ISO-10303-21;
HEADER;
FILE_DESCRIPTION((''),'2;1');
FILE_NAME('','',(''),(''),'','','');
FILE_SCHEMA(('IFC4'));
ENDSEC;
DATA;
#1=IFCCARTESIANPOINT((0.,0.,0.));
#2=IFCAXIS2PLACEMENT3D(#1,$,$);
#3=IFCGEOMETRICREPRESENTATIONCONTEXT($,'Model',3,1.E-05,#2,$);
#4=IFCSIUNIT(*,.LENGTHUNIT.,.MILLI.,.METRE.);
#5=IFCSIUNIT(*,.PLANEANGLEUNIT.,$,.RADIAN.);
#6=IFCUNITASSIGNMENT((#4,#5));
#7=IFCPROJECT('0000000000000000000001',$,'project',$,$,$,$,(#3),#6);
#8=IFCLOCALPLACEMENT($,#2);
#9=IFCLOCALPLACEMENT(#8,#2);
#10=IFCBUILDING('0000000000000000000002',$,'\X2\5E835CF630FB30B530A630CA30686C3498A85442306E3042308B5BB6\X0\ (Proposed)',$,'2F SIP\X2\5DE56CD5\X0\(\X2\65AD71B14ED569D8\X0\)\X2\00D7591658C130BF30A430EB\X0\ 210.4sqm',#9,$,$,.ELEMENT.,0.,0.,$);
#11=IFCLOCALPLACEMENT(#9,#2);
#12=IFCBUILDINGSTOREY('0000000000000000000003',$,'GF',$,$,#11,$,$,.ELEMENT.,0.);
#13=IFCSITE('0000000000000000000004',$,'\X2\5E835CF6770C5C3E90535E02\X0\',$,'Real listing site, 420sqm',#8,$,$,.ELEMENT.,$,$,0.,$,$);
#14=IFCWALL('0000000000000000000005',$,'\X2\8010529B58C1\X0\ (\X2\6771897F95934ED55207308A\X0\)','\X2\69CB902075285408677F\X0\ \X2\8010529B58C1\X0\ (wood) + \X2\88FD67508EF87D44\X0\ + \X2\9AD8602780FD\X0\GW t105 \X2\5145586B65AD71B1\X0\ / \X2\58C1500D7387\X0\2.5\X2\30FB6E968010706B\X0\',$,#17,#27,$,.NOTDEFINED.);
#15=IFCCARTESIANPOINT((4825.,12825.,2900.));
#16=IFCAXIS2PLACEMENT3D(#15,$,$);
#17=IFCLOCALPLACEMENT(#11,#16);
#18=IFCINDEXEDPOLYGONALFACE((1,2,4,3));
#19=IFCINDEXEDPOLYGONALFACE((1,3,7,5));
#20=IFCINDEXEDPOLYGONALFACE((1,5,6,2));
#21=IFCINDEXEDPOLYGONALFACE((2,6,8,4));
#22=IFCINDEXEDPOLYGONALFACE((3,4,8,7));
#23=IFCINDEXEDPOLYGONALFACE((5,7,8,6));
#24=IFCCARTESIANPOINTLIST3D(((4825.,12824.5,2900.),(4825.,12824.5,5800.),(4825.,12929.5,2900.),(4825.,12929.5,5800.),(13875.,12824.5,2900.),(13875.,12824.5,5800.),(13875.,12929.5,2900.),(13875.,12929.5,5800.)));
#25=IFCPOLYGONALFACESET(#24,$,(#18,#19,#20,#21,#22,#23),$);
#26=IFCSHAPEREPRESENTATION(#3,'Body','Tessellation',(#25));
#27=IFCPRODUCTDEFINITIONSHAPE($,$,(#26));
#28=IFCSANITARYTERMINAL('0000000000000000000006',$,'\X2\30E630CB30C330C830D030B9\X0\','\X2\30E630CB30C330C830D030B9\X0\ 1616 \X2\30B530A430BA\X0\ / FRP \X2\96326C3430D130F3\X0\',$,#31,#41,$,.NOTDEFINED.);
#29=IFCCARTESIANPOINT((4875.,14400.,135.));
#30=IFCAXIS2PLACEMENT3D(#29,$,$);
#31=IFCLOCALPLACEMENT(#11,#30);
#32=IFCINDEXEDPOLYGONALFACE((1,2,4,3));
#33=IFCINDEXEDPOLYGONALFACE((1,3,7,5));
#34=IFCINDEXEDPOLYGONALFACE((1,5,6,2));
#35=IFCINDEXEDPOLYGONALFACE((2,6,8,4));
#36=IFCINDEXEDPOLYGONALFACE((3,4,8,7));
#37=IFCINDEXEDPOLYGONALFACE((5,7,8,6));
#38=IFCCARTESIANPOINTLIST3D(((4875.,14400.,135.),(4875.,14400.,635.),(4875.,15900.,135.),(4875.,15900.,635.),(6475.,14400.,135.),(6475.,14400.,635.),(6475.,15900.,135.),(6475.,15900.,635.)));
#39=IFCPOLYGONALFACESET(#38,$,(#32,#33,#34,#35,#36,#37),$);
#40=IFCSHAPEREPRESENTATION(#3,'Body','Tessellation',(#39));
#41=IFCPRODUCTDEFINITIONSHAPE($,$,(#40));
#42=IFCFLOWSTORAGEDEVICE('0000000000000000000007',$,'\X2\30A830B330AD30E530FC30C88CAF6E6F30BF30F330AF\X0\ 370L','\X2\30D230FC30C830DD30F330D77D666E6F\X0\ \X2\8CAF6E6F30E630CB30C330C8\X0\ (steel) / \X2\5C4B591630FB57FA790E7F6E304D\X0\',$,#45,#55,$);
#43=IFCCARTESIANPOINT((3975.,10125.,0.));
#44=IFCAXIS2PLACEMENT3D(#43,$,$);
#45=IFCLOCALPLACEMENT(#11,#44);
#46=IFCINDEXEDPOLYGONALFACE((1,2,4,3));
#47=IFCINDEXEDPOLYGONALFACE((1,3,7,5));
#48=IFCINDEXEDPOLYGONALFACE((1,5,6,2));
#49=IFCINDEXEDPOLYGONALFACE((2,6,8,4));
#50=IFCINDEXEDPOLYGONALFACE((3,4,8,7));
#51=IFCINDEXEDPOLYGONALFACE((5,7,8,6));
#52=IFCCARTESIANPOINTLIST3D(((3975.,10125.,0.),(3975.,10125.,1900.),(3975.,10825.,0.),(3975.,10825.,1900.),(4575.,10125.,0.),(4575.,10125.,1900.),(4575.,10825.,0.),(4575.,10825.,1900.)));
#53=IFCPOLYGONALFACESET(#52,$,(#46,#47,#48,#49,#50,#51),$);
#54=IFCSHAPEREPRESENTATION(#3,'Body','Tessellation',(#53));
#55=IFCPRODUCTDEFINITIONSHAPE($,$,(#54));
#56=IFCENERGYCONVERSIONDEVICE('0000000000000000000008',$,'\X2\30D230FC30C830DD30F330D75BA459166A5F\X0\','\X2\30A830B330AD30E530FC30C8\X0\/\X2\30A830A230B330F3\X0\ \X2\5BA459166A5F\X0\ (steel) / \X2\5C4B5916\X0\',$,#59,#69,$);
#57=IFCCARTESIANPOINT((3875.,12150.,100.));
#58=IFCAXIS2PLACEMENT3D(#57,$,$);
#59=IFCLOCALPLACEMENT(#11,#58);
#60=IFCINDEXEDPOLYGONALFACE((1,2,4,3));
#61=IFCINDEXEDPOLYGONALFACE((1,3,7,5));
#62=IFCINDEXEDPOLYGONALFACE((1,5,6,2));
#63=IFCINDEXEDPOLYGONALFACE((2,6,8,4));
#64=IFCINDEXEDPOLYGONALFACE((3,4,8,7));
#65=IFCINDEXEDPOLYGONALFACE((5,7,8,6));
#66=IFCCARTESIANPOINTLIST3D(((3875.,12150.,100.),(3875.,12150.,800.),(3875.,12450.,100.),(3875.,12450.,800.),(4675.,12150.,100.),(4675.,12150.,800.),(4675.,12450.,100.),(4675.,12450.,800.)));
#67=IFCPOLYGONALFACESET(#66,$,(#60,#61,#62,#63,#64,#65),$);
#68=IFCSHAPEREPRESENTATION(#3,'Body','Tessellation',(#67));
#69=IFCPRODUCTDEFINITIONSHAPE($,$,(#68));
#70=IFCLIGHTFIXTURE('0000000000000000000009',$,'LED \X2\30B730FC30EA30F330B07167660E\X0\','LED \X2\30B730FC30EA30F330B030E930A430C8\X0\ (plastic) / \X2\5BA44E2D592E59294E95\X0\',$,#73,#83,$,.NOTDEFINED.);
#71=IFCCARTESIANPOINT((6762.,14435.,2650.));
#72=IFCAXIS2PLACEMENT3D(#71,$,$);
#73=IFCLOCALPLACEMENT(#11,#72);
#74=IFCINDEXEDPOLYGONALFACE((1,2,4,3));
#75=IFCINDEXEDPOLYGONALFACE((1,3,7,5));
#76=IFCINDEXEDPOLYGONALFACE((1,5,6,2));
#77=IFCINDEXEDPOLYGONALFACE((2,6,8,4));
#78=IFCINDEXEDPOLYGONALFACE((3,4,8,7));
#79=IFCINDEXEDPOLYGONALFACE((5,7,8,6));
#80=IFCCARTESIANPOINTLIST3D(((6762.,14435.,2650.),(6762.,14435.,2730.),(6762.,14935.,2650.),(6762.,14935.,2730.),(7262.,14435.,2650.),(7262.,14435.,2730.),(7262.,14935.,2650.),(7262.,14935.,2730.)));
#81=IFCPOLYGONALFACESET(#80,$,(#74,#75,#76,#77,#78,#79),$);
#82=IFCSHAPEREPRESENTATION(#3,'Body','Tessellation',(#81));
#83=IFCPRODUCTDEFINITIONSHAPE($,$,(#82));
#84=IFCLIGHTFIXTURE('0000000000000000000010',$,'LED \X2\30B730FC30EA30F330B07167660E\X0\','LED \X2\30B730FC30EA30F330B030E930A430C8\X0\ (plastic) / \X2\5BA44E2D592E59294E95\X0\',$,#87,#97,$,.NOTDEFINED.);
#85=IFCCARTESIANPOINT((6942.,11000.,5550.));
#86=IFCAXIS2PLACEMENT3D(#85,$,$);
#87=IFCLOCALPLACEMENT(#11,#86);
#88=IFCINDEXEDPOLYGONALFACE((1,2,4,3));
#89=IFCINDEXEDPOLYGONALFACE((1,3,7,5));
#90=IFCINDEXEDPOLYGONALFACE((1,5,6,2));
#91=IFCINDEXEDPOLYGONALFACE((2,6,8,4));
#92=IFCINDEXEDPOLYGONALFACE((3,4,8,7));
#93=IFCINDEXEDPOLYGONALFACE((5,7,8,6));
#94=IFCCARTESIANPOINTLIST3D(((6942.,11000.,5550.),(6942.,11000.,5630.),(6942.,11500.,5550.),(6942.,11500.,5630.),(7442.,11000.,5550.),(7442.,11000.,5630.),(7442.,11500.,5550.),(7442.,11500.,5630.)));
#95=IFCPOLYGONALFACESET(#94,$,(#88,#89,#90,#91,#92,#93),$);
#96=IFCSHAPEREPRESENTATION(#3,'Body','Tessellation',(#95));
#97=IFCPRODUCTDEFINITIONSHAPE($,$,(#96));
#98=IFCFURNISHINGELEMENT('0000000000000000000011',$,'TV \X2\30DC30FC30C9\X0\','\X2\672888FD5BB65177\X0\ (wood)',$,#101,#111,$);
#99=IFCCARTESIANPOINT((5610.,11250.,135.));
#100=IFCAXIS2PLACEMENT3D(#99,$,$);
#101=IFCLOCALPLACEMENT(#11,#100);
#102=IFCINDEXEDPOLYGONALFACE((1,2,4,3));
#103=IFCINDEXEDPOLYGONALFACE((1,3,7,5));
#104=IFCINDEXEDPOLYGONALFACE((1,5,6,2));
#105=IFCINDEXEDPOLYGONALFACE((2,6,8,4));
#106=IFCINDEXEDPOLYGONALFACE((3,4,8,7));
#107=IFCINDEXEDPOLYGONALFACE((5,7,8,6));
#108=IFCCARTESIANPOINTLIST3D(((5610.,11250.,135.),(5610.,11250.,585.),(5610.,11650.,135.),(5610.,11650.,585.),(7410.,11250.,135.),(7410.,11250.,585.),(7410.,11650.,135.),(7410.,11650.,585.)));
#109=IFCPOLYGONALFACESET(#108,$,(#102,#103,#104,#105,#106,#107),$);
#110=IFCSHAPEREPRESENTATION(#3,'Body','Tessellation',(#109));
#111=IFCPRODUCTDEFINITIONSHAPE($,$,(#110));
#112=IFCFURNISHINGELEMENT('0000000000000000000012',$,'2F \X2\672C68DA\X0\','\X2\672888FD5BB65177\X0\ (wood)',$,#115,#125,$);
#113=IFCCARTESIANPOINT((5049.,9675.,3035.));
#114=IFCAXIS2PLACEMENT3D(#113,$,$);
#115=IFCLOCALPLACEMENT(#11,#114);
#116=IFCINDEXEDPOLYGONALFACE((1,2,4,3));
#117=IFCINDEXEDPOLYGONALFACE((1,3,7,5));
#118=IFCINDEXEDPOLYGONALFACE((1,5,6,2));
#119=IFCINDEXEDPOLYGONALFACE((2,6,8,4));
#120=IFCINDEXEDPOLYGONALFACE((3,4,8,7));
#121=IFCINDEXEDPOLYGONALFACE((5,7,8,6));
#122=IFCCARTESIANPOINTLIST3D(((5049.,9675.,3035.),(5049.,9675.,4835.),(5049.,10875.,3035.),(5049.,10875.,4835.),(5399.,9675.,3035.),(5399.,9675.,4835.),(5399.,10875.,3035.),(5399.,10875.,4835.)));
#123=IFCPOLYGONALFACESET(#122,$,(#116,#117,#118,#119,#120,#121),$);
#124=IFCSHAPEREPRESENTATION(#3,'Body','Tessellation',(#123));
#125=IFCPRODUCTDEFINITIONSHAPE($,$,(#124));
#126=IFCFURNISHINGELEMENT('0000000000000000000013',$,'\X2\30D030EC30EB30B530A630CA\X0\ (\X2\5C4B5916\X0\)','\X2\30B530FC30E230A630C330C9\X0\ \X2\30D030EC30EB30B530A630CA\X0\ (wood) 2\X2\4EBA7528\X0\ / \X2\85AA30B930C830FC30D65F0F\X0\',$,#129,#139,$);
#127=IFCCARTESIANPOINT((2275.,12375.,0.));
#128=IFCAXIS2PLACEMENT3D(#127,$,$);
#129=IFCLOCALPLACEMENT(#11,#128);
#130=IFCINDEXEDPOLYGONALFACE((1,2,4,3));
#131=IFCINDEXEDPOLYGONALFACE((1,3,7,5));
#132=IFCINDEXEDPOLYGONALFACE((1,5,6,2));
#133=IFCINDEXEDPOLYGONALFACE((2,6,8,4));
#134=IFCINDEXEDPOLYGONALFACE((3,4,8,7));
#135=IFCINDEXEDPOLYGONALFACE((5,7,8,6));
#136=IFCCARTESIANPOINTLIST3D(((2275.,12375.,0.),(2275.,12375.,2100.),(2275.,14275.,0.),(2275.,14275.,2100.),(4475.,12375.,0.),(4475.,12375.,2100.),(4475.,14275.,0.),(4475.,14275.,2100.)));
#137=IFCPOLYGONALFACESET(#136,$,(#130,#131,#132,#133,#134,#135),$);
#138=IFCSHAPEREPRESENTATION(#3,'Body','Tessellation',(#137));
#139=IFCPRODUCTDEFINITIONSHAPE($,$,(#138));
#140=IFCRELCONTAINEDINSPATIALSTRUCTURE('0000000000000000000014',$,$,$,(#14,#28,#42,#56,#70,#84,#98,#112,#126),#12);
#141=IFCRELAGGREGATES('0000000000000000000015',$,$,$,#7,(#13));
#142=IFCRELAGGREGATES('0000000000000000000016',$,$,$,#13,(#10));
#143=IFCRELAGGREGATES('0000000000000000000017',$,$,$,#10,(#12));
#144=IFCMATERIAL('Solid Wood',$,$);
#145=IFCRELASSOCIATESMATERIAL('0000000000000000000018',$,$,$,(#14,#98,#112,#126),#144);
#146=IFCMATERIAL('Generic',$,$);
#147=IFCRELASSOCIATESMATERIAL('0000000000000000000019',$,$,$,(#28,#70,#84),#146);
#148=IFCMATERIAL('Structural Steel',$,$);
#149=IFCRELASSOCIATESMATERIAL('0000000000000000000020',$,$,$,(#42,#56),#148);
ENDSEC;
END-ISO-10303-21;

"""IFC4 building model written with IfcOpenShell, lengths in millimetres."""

from ifc_helpers import new_model, si_unit, frame, frame_2d, origin, place, context, project, spatial, rectangle, extrude, material, element, save


model = new_model("IFC4")

# Units and contexts
model_context = context("Model", 3, precision=1e-05, world=origin())
ifc_project = project(units=[si_unit("LENGTHUNIT", "METRE", prefix="MILLI"), si_unit("PLANEANGLEUNIT", "RADIAN")], contexts=[model_context])

# Site, building, storey
site_placement = place(None, origin())
site = spatial("IfcSite", under=ifc_project, at=site_placement, Name="広島県尾道市", ObjectType="Real listing site, 420sqm", CompositionType="ELEMENT", RefElevation=0.0)
building_placement = place(site_placement, origin())
building = spatial("IfcBuilding", under=site, at=building_placement, Name="広島・サウナと水風呂のある家 (Proposed)", ObjectType="2F SIP工法(断熱仕様)×外壁タイル 210.4sqm", CompositionType="ELEMENT", ElevationOfRefHeight=0.0, ElevationOfTerrain=0.0)
storey_placement = place(building_placement, origin())
storey = spatial("IfcBuildingStorey", under=building, at=storey_placement, Name="GF", CompositionType="ELEMENT", Elevation=0.0)

# Shared definitions
ifc_material_1 = material(Name="Solid Wood")

# Wall
wall_1_placement = place(storey_placement, frame((4825.0, 12825.0, 2900.0)))
element("IfcWall", 1, at=wall_1_placement, inside=storey, material=ifc_material_1, Name="耐力壁 (東西間仕切り)", Description="構造用合板 耐力壁 (wood) + 製材軸組 + 高性能GW t105 充填断熱 / 壁倍率2.5・準耐火", PredefinedType="NOTDEFINED", context=model_context, shape_type="SweptSolid", body=[
    extrude(rectangle(XDim=9050.0, YDim=105.0, at=frame_2d((4525.0, 52.0))), frame((4825.0, 12825.0, 2900.0)), (0.0, 0.0, 1.0), 2900.0),
])

# Sanitary terminal
ifc_material_2 = material(Name="Generic")
sanitary_terminal_placement = place(storey_placement, frame((4875.0, 14400.0, 135.0)))
element("IfcSanitaryTerminal", 2, at=sanitary_terminal_placement, inside=storey, material=ifc_material_2, Name="ユニットバス", Description="ユニットバス 1616 サイズ / FRP 防水パン", PredefinedType="NOTDEFINED", context=model_context, shape_type="SweptSolid", body=[
    extrude(rectangle(XDim=1600.0, YDim=1500.0, at=frame_2d((800.0, 750.0))), frame((4875.0, 14400.0, 135.0)), (0.0, 0.0, 1.0), 500.0),
])

# Flow storage device
ifc_material_3 = material(Name="Structural Steel")
flow_storage_device_placement = place(storey_placement, frame((3975.0, 10125.0, 0.0)))
element("IfcFlowStorageDevice", 3, at=flow_storage_device_placement, inside=storey, material=ifc_material_3, Name="エコキュート貯湯タンク 370L", Description="ヒートポンプ給湯 貯湯ユニット (steel) / 屋外・基礎置き", context=model_context, shape_type="SweptSolid", body=[
    extrude(rectangle(XDim=600.0, YDim=700.0, at=frame_2d((300.0, 350.0))), frame((3975.0, 10125.0, 0.0)), (0.0, 0.0, 1.0), 1900.0),
])

# Energy conversion device
energy_conversion_device_placement = place(storey_placement, frame((3875.0, 12150.0, 100.0)))
element("IfcEnergyConversionDevice", 4, at=energy_conversion_device_placement, inside=storey, material=ifc_material_3, Name="ヒートポンプ室外機", Description="エコキュート/エアコン 室外機 (steel) / 屋外", context=model_context, shape_type="SweptSolid", body=[
    extrude(rectangle(XDim=800.0, YDim=300.0, at=frame_2d((400.0, 150.0))), frame((3875.0, 12150.0, 100.0)), (0.0, 0.0, 1.0), 700.0),
])

# Light fixtures
light_fixture_1_placement = place(storey_placement, frame((6762.0, 14435.0, 2650.0)))
element("IfcLightFixture", 5, at=light_fixture_1_placement, inside=storey, material=ifc_material_2, Name="LED シーリング照明", Description="LED シーリングライト (plastic) / 室中央天井", PredefinedType="NOTDEFINED", context=model_context, shape_type="SweptSolid", body=[
    extrude(rectangle(XDim=500.0, YDim=500.0, at=frame_2d((250.0, 250.0))), frame((6762.0, 14435.0, 2650.0)), (0.0, 0.0, 1.0), 80.0),
])
light_fixture_2_placement = place(storey_placement, frame((6942.0, 11000.0, 5550.0)))
element("IfcLightFixture", 6, at=light_fixture_2_placement, inside=storey, material=ifc_material_2, Name="LED シーリング照明", Description="LED シーリングライト (plastic) / 室中央天井", PredefinedType="NOTDEFINED", context=model_context, shape_type="SweptSolid", body=[
    extrude(rectangle(XDim=500.0, YDim=500.0, at=frame_2d((250.0, 250.0))), frame((6942.0, 11000.0, 5550.0)), (0.0, 0.0, 1.0), 80.0),
])

# Furnishing elements
furnishing_1_placement = place(storey_placement, frame((5610.0, 11250.0, 135.0)))
element("IfcFurnishingElement", 7, at=furnishing_1_placement, inside=storey, material=ifc_material_1, Name="TV ボード", Description="木製家具 (wood)", context=model_context, shape_type="SweptSolid", body=[
    extrude(rectangle(XDim=1800.0, YDim=400.0, at=frame_2d((900.0, 200.0))), frame((5610.0, 11250.0, 135.0)), (0.0, 0.0, 1.0), 450.0),
])
furnishing_2_placement = place(storey_placement, frame((5049.0, 9675.0, 3035.0)))
element("IfcFurnishingElement", 8, at=furnishing_2_placement, inside=storey, material=ifc_material_1, Name="2F 本棚", Description="木製家具 (wood)", context=model_context, shape_type="SweptSolid", body=[
    extrude(rectangle(XDim=350.0, YDim=1200.0, at=frame_2d((175.0, 600.0))), frame((5049.0, 9675.0, 3035.0)), (0.0, 0.0, 1.0), 1800.0),
])
furnishing_3_placement = place(storey_placement, frame((2275.0, 12375.0, 0.0)))
element("IfcFurnishingElement", 9, at=furnishing_3_placement, inside=storey, material=ifc_material_1, Name="バレルサウナ (屋外)", Description="サーモウッド バレルサウナ (wood) 2人用 / 薪ストーブ式", context=model_context, shape_type="SweptSolid", body=[
    extrude(rectangle(XDim=2200.0, YDim=1900.0, at=frame_2d((1100.0, 950.0))), frame((2275.0, 12375.0, 0.0)), (0.0, 0.0, 1.0), 2100.0),
])

save(model, "model.ifc")
